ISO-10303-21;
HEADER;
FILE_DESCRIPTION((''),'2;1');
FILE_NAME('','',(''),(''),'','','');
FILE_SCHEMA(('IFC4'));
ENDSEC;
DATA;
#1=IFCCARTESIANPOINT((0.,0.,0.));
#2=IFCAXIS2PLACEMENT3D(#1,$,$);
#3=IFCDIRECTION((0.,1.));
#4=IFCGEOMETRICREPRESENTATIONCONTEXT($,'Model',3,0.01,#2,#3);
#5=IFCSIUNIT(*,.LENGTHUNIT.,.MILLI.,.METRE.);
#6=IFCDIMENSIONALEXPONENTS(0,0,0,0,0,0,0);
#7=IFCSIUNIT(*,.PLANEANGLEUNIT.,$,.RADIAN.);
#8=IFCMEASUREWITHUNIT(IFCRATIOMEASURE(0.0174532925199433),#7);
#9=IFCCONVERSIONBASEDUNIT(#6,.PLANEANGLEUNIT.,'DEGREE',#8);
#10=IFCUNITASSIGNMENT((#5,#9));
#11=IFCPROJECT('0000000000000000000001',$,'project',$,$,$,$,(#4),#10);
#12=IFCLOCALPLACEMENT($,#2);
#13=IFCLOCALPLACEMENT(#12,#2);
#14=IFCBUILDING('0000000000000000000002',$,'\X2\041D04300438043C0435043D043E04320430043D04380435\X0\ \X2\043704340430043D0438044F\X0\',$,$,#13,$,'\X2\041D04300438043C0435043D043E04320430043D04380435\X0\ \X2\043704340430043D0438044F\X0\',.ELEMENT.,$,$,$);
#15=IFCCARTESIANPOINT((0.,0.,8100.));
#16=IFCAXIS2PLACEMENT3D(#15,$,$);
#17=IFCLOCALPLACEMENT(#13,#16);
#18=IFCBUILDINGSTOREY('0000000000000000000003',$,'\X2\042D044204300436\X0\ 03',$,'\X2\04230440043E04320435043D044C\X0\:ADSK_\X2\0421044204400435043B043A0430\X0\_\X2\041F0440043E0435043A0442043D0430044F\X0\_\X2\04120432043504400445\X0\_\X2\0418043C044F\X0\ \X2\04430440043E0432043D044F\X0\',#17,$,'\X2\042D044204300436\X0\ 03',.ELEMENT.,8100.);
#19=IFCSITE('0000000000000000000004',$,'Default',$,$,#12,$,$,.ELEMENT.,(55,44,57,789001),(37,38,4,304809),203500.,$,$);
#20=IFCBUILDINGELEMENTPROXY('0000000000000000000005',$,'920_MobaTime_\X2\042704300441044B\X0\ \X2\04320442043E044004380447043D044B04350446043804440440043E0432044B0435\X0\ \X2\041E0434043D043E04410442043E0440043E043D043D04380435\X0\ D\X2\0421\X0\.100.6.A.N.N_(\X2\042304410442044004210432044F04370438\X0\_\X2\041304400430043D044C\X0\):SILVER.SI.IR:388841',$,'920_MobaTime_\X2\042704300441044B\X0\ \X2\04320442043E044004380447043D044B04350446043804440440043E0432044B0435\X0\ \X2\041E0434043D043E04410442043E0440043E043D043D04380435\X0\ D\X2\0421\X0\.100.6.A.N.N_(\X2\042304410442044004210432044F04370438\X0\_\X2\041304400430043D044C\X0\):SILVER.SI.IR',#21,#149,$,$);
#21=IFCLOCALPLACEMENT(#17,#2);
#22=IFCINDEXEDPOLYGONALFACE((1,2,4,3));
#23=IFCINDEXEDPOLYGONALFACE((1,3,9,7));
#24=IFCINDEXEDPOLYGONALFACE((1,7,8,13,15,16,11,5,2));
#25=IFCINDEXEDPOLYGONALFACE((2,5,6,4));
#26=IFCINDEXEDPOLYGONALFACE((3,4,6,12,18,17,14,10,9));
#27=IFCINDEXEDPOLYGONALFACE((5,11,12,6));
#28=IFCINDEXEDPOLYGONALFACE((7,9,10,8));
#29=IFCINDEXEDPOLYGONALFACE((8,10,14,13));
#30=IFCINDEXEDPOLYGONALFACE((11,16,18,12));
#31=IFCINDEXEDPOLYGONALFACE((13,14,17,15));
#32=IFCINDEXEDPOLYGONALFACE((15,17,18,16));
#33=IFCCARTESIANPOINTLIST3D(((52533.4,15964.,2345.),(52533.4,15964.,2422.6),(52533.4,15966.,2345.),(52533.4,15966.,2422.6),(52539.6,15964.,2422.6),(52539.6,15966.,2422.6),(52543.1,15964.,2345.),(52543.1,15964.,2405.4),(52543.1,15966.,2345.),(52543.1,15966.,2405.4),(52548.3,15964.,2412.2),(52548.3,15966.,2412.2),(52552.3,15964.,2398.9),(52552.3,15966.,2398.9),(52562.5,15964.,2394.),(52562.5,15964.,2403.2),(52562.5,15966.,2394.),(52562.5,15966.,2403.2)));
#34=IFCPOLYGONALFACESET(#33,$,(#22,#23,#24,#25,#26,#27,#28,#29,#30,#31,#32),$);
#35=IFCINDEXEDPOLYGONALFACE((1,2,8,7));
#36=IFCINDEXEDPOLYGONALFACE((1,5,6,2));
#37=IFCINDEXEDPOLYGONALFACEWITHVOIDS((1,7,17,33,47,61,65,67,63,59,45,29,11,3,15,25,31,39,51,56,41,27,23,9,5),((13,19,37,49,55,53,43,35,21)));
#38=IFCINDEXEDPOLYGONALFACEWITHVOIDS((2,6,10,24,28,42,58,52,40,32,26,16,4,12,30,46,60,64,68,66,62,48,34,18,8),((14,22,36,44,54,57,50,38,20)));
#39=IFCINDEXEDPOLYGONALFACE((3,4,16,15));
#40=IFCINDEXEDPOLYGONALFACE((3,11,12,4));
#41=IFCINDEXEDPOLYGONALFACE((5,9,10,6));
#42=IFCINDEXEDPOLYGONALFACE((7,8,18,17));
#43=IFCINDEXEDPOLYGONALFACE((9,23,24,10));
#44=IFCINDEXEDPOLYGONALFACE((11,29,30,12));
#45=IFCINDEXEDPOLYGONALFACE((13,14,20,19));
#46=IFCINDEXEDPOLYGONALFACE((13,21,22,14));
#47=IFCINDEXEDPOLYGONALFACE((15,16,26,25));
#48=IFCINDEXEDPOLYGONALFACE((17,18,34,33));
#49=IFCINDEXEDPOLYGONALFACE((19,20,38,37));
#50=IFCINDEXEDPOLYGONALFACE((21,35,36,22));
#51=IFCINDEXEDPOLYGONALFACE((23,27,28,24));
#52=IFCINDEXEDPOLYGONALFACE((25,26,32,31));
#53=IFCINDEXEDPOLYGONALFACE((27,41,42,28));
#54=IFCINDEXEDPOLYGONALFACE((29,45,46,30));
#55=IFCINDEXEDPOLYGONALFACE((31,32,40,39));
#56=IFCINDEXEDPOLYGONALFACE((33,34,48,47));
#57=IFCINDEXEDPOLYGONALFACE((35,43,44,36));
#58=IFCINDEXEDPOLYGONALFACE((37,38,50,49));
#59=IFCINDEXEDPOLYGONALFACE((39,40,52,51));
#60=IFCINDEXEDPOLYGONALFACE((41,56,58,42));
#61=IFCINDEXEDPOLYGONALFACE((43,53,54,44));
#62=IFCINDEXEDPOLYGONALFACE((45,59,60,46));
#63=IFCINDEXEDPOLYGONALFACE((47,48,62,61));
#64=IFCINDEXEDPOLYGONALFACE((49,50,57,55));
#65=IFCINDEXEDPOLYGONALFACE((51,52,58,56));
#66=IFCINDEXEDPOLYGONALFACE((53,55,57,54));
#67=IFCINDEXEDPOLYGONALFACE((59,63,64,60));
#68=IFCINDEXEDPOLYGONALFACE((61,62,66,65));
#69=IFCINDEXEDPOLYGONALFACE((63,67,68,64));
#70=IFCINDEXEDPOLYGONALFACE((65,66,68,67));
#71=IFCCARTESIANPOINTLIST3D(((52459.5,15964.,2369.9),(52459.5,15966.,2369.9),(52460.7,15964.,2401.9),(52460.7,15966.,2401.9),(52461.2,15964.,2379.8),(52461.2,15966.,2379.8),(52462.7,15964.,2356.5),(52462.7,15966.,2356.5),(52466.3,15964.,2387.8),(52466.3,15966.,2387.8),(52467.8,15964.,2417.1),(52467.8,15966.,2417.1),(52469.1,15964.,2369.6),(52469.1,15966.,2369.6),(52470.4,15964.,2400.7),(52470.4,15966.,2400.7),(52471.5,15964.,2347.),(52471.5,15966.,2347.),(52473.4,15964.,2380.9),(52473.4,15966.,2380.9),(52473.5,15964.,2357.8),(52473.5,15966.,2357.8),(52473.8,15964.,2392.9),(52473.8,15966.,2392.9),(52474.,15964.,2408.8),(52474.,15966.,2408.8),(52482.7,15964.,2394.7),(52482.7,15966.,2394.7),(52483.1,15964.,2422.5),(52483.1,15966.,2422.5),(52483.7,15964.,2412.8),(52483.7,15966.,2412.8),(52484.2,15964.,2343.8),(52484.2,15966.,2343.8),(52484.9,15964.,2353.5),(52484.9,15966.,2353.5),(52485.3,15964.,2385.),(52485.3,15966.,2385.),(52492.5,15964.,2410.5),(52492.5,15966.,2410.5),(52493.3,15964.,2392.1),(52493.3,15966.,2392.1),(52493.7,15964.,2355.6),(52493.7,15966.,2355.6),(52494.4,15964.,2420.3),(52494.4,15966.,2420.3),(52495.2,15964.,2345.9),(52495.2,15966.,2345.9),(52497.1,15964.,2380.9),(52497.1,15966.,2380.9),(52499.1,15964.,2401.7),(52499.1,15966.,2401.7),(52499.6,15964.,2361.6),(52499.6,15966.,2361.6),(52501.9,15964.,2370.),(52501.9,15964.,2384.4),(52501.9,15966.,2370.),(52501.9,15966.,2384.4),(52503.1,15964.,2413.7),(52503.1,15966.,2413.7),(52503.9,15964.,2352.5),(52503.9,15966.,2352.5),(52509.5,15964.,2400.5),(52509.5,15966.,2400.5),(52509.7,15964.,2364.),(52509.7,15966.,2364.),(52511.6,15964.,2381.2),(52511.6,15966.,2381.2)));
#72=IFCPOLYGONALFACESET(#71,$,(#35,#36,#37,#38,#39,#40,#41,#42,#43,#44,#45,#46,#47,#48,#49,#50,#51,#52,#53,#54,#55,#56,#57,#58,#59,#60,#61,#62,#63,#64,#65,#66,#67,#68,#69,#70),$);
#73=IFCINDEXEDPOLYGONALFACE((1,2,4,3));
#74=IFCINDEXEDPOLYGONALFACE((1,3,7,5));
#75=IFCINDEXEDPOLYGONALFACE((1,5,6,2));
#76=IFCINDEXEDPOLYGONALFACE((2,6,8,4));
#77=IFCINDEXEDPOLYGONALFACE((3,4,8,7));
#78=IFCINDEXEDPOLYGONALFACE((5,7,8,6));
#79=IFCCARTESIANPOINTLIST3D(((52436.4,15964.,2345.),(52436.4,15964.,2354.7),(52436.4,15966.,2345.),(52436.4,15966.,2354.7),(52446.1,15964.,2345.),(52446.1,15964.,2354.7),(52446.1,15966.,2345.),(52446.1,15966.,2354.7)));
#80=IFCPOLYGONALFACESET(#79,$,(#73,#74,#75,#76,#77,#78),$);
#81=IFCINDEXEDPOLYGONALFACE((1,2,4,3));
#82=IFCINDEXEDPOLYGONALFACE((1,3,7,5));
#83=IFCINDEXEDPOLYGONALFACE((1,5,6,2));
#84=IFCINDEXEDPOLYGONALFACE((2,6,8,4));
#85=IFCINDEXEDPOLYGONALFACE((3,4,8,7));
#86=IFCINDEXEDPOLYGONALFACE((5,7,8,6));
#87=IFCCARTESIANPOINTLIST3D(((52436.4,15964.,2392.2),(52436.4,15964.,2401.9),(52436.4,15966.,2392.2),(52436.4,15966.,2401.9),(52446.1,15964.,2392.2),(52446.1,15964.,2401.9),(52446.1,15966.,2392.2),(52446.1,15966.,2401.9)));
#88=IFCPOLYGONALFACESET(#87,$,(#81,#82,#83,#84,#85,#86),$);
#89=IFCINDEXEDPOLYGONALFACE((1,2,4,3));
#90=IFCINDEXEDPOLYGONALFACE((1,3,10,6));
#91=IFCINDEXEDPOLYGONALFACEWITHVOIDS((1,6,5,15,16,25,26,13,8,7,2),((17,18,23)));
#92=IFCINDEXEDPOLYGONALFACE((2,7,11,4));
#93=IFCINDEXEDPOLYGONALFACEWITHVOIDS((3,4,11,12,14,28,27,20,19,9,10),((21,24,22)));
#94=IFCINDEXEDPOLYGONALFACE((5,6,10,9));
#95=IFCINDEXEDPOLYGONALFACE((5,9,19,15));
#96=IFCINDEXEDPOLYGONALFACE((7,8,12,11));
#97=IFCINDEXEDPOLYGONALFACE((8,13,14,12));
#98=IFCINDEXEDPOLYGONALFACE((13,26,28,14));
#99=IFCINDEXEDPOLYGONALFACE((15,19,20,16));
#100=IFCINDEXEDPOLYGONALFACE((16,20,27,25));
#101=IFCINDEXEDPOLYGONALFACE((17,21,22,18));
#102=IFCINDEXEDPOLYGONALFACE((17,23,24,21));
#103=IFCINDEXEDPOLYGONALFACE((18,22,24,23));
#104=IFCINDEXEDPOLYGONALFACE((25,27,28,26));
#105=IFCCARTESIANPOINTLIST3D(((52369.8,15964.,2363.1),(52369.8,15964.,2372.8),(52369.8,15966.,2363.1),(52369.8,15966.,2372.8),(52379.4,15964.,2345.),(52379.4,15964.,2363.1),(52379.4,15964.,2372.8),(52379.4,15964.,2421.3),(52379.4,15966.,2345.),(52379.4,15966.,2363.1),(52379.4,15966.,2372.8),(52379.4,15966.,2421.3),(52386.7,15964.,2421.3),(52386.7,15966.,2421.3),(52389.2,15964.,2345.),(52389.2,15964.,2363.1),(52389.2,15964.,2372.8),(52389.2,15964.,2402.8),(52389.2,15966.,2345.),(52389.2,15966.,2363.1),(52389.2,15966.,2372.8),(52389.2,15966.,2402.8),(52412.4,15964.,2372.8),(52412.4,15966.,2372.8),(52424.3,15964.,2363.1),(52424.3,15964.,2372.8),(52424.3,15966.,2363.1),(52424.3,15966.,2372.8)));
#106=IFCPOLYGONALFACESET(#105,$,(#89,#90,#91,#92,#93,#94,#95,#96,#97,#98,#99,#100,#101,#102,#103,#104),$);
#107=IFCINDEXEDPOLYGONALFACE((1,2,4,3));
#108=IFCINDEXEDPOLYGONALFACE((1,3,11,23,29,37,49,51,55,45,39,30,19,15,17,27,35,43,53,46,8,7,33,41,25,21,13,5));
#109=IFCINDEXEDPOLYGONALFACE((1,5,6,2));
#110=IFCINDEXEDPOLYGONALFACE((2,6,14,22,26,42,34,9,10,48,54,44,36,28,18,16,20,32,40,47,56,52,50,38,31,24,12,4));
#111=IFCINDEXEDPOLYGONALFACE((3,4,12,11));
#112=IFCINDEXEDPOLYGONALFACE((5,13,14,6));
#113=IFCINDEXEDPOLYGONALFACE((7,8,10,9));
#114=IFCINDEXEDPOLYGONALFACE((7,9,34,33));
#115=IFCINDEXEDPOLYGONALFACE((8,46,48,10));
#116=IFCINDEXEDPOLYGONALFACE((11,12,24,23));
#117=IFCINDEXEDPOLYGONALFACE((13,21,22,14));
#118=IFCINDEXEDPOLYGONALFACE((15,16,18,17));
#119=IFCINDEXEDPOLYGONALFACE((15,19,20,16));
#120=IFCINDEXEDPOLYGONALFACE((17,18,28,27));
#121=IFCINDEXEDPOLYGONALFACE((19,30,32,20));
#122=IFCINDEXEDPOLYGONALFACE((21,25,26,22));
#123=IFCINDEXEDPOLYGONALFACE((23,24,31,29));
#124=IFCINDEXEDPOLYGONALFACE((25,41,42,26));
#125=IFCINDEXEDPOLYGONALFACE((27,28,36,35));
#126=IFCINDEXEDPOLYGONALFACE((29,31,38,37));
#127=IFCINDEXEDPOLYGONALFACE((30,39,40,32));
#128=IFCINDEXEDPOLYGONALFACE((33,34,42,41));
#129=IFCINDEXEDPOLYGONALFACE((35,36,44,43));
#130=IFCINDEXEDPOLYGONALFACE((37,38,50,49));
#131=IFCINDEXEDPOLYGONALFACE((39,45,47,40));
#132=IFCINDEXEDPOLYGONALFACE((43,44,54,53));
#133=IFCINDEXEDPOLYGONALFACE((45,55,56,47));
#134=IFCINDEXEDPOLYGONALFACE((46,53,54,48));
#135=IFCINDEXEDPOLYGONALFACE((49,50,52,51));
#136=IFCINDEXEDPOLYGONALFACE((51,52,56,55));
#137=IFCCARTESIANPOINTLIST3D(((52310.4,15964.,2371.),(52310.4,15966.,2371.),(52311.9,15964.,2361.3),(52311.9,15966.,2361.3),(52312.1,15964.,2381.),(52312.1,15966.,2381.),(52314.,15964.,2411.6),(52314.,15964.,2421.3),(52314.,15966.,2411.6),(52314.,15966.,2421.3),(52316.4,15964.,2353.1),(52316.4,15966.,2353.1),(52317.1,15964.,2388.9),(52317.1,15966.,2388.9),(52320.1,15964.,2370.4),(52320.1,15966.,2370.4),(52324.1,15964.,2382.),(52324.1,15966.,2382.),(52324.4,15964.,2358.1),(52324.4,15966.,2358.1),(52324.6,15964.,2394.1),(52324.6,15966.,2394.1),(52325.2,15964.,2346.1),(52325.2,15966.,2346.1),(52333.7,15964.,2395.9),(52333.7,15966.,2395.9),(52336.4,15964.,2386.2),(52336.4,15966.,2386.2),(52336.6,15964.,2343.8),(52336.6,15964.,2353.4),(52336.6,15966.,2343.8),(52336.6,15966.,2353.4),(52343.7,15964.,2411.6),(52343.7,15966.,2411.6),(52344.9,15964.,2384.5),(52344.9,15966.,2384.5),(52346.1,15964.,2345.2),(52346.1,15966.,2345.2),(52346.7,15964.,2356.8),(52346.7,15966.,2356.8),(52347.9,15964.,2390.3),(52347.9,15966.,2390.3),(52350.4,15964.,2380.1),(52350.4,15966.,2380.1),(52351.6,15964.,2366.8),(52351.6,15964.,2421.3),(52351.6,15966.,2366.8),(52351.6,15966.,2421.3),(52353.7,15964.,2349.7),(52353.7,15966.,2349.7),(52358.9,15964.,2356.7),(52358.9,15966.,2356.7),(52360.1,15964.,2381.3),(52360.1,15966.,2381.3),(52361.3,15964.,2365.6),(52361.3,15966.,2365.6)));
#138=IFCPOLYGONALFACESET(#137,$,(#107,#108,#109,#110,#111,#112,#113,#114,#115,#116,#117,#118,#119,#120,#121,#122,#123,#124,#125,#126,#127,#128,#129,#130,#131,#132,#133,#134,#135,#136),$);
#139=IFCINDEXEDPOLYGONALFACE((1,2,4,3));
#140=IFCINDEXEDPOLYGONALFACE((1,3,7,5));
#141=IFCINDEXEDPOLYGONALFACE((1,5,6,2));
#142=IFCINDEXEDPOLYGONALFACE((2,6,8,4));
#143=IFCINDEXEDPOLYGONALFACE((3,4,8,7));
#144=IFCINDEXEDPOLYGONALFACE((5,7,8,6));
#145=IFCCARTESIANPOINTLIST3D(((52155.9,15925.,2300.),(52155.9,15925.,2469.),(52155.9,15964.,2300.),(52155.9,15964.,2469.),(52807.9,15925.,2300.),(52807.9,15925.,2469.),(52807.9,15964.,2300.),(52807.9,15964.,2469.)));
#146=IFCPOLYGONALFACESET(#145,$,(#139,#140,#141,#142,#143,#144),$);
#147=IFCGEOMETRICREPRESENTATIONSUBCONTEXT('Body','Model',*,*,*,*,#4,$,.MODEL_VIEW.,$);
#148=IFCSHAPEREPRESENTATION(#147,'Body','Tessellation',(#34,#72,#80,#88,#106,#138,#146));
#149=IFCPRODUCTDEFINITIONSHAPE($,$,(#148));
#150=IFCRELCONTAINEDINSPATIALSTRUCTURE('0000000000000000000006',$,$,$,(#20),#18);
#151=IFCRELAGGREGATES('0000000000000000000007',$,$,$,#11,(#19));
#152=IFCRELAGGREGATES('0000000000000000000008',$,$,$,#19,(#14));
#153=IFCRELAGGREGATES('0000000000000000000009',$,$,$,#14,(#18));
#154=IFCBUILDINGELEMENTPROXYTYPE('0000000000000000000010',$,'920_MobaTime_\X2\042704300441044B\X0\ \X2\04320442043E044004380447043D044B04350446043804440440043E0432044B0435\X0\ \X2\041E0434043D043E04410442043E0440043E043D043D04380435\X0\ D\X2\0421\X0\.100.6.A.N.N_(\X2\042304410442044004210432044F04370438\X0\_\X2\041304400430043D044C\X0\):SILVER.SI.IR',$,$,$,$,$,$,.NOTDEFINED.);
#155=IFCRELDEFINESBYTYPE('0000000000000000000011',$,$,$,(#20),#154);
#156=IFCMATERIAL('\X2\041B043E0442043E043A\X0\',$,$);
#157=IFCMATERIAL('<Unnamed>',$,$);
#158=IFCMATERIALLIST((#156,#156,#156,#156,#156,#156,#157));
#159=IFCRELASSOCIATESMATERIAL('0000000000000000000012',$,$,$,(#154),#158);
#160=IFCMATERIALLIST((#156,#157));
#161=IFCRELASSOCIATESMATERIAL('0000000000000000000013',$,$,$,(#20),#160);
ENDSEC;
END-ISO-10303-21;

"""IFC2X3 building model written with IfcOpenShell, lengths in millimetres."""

from ifc_helpers import new_model, entity, si_unit, converted_unit, direction, frame, origin, origin_2d_with_axis, place, context, subcontext, project, spatial, polyline, rectangle, outline, extrude, source, transform, mapped, material, material_list, type_object, type_shapes, element, save


model = new_model("IFC2X3")

# Units and contexts
model_context = context("Model", 3, precision=0.01, world=origin(), true_north=direction((0.0, 1.0)))
body_context = subcontext(model_context, "Body", "Model", "MODEL_VIEW")
ifc_project = project(units=[si_unit("LENGTHUNIT", "METRE", prefix="MILLI"), converted_unit("PLANEANGLEUNIT", "DEGREE", entity("IfcRatioMeasure", 0.0174532925199433), si_unit("PLANEANGLEUNIT", "RADIAN"), dimensions=[0, 0, 0, 0, 0, 0, 0])], contexts=[model_context])

# Site, building, storey
site_placement = place(None, origin())
site = spatial("IfcSite", under=ifc_project, at=site_placement, Name="Default", CompositionType="ELEMENT", RefLatitude=(55, 44, 57, 789001), RefLongitude=(37, 38, 4, 304809), RefElevation=203500.0)
building_placement = place(site_placement, origin())
building = spatial("IfcBuilding", under=site, at=building_placement, Name="Наименование здания", LongName="Наименование здания", CompositionType="ELEMENT")
storey_placement = place(building_placement, frame((0.0, 0.0, 8100.0)))
storey = spatial("IfcBuildingStorey", under=building, at=storey_placement, Name="Этаж 03", ObjectType="Уровень:ADSK_Стрелка_Проектная_Вверх_Имя уровня", LongName="Этаж 03", CompositionType="ELEMENT", Elevation=8100.0)

# Building element proxy
ifc_material_1 = material(Name="Лоток")
ifc_material_2 = material(Name="<Unnamed>")
ifc_material_list_1 = material_list([ifc_material_1, ifc_material_1, ifc_material_1, ifc_material_1, ifc_material_1, ifc_material_1, ifc_material_2])
building_element_proxy_type = type_object("IfcBuildingElementProxyType", Name="920_MobaTime_Часы вторичныецифровые Односторонние DС.100.6.A.N.N_(УстрСвязи_Грань):SILVER.SI.IR", PredefinedType="NOTDEFINED", material=ifc_material_list_1)
shared_shape = source(origin(), body_context, "Body", "SweptSolid", [
    extrude(outline(polyline([(-49.3, -13.1), (28.2, -13.1), (28.2, -6.8), (17.9, 1.8), (8.8, 16.0), (-0.3, 16.0), (4.6, 5.8), (11.1, -3.4), (-49.3, -3.4), (-49.3, -13.1)])), frame((-64.6, 9.8, 39.0), z_axis=(0.0, 0.0, 1.0), x_axis=(0.0, 1.0, 0.0)), (0.0, 0.0, 1.0), 2.0),
    extrude(outline(polyline([(2.2, -27.6), (19.0, -27.6), (30.5, -16.1), (33.3, -4.9), (31.0, 5.8), (21.8, 17.2), (5.2, 27.3), (-11.1, 33.0), (-24.0, 32.7), (-33.6, 27.6), (-40.3, 18.6), (-42.8, 5.7), (-38.0, -6.3), (-27.2, -14.9), (-17.5, -17.7), (-8.2, -16.4), (-0.3, -11.9), (5.1, -4.5), (7.3, 6.2), (4.0, 17.2), (18.4, 7.3), (23.6, -2.4), (22.0, -11.4), (14.2, -18.4), (5.3, -18.3), (2.2, -27.6)]), holes=[polyline([(-9.0, 23.3), (-1.3, 14.3), (-2.5, 2.0), (-11.4, -7.0), (-23.4, -6.0), (-32.2, 2.9), (-31.2, 15.1), (-25.6, 22.1), (-17.5, 24.9), (-9.0, 23.3)])]), frame((-2.7, 3.6, 39.0), z_axis=(0.0, 0.0, 1.0), x_axis=(-0.427649, 0.903945, 0.0)), (0.0, 0.0, 1.0), 2.0),
    extrude(rectangle(XDim=9.7, YDim=9.7, at=origin_2d_with_axis()), frame((40.6, -34.7, 39.0)), (0.0, 0.0, 1.0), 2.0),
    extrude(rectangle(XDim=9.7, YDim=9.7, at=origin_2d_with_axis()), frame((40.6, 12.6, 39.0)), (0.0, 0.0, 1.0), 2.0),
    extrude(outline(polyline([(-0.9, -28.1), (8.8, -28.1), (8.8, -9.9), (18.5, -9.9), (18.5, -0.2), (8.8, -0.2), (8.8, 48.3), (1.5, 48.3), (-36.0, -0.2), (-36.0, -9.9), (-0.9, -9.9), (-0.9, -28.1)]), holes=[polyline([(-0.9, -0.2), (-24.1, -0.2), (-0.9, 29.7), (-0.9, -0.2)])]), frame((93.6, -11.4, 39.0)), (0.0, 0.0, 1.0), 2.0),
    extrude(outline(polyline([(3.3, -28.3), (12.5, -28.3), (20.5, -25.0), (26.8, -18.9), (30.7, -10.0), (31.4, 1.6), (26.9, 11.8), (20.1, 18.4), (11.1, 22.3), (1.0, 23.3), (-7.9, 20.4), (-14.9, 14.5), (-18.9, 6.2), (-17.1, -9.0), (-36.7, 0.5), (-29.1, 29.2), (-38.5, 31.7), (-48.1, -4.6), (-11.6, -23.1), (-8.0, -14.0), (-10.8, -7.6), (-10.2, 1.1), (-3.0, 11.8), (9.2, 12.8), (20.0, 5.5), (21.4, -7.5), (15.5, -16.4), (4.6, -18.6), (3.3, -28.3)])), frame((147.1, -8.5, 39.0), z_axis=(0.0, 0.0, 1.0), x_axis=(0.256974, -0.966418, 0.0)), (0.0, 0.0, 1.0), 2.0),
    extrude(rectangle(XDim=652.0, YDim=169.0, at=origin_2d_with_axis()), frame((0.0, 0.0, 0.0), z_axis=(0.0, 0.0, 1.0), x_axis=(-1.0, 0.0, 0.0)), (0.0, 0.0, 1.0), 39.0),
])
type_shapes(building_element_proxy_type, [shared_shape])
ifc_material_list_2 = material_list([ifc_material_1, ifc_material_2])
for number, where, z_axis, x_axis, name in (
    (1, (52481.9, 15925.0, 2384.5), (0.0, 1.0, 0.0), (-1.0, 0.0, 0.0), "920_MobaTime_Часы вторичныецифровые Односторонние DС.100.6.A.N.N_(УстрСвязи_Грань):SILVER.SI.IR:388841"),
):
    element("IfcBuildingElementProxy", number, at=place(storey_placement, frame(where, z_axis=z_axis, x_axis=x_axis)), inside=storey, type_object=building_element_proxy_type, material=ifc_material_list_2, Name=name, ObjectType="920_MobaTime_Часы вторичныецифровые Односторонние DС.100.6.A.N.N_(УстрСвязи_Грань):SILVER.SI.IR", context=body_context, shape_type="MappedRepresentation", body=[
        mapped(shared_shape, transform((0.0, 0.0, 0.0), scale=1.0)),
    ])

save(model, "model.ifc")
